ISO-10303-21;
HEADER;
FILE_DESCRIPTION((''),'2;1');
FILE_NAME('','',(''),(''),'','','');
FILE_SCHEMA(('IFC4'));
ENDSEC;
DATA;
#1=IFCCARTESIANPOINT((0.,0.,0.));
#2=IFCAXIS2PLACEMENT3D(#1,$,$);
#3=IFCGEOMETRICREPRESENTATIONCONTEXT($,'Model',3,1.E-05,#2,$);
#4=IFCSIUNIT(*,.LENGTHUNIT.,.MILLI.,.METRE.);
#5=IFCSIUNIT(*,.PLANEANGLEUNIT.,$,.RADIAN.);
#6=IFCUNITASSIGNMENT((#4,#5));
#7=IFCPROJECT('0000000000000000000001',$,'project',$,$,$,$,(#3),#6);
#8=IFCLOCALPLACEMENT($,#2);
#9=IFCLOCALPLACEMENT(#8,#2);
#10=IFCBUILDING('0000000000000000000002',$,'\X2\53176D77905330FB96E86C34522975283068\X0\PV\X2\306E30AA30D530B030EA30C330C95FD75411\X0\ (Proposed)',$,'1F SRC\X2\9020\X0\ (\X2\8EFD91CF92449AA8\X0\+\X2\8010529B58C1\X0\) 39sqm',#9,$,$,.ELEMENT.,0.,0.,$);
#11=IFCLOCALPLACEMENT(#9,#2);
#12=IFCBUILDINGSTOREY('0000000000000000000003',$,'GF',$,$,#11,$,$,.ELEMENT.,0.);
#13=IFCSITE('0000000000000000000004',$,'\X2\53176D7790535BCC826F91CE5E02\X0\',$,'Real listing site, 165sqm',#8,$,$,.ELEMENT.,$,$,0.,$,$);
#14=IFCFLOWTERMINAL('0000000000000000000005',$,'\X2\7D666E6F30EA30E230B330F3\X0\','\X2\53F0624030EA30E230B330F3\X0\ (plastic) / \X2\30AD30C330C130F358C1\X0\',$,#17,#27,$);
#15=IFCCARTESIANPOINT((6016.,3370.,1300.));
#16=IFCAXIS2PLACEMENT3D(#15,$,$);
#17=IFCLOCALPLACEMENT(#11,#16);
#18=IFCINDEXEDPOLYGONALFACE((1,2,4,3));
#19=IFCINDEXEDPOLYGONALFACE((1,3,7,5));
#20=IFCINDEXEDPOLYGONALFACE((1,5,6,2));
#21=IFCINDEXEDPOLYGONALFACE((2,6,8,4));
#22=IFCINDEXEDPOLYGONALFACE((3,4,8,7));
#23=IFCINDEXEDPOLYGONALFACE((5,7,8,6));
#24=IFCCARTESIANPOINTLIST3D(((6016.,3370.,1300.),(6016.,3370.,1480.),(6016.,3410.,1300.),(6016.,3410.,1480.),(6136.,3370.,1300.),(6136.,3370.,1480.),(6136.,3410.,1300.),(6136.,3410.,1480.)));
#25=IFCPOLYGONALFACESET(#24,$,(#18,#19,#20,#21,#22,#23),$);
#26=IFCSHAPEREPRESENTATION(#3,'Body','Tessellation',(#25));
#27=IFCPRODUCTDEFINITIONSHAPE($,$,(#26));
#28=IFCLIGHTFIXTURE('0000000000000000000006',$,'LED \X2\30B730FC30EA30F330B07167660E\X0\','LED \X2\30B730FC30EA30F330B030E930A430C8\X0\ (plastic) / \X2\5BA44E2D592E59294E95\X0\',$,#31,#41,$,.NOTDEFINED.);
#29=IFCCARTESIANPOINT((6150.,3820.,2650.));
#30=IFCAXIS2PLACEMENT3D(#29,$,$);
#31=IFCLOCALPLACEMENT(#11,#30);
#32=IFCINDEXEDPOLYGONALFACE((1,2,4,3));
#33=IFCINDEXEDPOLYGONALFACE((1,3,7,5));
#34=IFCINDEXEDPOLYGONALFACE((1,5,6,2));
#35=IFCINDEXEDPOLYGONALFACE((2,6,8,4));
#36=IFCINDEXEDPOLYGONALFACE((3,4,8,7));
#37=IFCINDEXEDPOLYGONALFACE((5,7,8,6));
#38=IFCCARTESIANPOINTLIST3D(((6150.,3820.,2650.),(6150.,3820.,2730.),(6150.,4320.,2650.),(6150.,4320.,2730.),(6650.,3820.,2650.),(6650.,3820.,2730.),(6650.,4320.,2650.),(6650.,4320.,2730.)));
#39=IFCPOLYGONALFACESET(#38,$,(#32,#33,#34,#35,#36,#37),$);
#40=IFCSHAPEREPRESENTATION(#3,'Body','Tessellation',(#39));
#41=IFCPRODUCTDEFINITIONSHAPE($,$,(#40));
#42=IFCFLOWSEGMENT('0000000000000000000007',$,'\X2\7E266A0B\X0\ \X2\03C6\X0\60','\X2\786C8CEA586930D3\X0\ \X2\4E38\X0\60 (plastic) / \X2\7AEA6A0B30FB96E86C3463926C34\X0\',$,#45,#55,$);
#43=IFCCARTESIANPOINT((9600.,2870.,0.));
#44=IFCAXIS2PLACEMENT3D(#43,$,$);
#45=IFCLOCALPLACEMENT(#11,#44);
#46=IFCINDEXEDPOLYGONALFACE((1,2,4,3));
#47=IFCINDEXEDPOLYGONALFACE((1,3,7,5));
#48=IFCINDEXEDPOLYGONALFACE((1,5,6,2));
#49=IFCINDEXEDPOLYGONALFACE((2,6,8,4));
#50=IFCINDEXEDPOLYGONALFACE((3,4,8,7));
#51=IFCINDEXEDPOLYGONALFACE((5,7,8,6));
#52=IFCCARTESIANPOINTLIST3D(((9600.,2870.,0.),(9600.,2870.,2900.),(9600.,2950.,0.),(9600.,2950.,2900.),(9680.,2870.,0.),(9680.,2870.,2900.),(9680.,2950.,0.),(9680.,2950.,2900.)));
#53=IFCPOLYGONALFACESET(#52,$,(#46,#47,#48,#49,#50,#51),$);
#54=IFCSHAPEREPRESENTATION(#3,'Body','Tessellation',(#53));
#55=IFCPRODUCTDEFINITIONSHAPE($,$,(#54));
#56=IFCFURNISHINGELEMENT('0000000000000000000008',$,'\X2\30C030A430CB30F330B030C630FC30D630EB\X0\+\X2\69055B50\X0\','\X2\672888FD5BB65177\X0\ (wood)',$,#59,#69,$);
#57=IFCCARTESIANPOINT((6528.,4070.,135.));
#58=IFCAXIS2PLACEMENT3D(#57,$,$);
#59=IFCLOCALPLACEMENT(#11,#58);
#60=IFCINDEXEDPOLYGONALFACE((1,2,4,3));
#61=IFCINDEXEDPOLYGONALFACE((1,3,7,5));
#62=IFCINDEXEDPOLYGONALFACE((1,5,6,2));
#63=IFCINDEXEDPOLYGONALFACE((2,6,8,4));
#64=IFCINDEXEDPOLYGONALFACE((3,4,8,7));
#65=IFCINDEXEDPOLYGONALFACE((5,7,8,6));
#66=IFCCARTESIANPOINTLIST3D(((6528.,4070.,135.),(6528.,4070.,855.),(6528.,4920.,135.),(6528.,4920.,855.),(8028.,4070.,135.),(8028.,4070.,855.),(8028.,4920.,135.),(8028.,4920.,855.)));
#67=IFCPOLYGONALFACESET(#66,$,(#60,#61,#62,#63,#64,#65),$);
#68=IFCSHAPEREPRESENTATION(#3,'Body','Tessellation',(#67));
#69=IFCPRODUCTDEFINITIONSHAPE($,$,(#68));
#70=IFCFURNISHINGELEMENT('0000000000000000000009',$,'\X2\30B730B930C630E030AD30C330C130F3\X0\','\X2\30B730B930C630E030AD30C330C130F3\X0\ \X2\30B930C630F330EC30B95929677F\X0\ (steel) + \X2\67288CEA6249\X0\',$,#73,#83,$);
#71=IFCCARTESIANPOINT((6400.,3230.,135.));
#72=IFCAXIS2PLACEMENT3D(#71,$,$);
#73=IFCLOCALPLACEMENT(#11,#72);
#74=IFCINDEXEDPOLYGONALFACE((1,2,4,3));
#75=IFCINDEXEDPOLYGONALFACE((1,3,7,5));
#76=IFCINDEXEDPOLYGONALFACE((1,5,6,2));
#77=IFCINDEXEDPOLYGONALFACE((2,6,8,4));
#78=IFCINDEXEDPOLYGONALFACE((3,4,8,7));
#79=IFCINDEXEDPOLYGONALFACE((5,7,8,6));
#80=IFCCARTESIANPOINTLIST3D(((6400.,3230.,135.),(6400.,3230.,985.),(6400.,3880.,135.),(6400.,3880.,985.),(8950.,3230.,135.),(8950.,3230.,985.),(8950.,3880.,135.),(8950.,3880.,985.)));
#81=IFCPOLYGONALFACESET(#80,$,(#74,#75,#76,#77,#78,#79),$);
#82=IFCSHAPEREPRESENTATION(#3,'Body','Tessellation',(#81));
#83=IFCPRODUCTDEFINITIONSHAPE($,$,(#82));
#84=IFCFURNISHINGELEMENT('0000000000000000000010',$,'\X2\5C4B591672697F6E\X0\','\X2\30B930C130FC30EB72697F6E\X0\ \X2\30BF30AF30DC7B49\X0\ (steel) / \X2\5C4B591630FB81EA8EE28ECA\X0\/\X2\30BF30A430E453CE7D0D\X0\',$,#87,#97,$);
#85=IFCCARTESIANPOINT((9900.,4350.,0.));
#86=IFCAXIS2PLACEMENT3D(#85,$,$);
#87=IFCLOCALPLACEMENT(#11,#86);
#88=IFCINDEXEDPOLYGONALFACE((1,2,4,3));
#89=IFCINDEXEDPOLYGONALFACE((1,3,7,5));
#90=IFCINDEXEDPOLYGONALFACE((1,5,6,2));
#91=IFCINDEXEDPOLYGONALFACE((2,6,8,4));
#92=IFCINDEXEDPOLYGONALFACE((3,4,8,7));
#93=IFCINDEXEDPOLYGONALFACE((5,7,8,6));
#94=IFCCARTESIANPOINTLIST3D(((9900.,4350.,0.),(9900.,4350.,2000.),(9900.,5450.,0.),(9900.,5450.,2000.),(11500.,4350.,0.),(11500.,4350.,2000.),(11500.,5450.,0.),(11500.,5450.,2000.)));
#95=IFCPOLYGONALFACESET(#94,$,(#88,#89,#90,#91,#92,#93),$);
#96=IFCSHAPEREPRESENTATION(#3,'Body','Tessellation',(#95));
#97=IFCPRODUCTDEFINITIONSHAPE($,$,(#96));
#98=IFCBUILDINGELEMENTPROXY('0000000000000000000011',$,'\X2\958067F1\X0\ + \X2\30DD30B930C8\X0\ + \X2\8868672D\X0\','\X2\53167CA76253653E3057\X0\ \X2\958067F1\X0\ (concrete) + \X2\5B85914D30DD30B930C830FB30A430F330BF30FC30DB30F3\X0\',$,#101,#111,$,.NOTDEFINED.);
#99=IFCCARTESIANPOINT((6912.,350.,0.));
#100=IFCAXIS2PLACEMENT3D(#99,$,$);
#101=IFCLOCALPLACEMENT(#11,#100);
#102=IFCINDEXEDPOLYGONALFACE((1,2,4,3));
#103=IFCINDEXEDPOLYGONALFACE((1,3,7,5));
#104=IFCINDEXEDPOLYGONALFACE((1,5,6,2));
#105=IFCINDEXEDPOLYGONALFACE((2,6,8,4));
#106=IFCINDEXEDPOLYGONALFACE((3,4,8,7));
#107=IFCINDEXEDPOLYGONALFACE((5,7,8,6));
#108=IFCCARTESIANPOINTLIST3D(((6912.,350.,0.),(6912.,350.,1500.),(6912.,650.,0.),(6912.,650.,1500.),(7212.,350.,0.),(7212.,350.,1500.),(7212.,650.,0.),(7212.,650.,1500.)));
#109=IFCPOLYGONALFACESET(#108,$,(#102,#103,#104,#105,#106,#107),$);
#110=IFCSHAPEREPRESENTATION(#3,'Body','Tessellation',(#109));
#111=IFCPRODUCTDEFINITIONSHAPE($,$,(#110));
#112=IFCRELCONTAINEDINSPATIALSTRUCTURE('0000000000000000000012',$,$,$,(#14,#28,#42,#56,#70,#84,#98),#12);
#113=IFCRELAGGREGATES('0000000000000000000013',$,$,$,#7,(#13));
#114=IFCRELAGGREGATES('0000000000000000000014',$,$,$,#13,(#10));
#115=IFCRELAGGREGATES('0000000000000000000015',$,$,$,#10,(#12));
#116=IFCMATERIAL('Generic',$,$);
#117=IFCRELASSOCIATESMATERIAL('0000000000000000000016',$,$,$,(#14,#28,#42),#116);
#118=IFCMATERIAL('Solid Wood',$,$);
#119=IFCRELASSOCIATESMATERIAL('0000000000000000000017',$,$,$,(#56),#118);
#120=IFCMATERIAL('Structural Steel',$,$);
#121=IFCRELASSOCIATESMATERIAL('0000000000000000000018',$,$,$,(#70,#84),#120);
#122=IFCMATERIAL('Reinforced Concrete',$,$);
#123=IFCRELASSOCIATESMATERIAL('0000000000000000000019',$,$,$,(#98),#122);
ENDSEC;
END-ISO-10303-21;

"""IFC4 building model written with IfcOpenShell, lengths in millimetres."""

from ifc_helpers import new_model, si_unit, frame, frame_2d, origin, place, context, project, spatial, rectangle, extrude, material, element, save


model = new_model("IFC4")

# Units and contexts
model_context = context("Model", 3, precision=1e-05, world=origin())
ifc_project = project(units=[si_unit("LENGTHUNIT", "METRE", prefix="MILLI"), si_unit("PLANEANGLEUNIT", "RADIAN")], contexts=[model_context])

# Site, building, storey
site_placement = place(None, origin())
site = spatial("IfcSite", under=ifc_project, at=site_placement, Name="北海道富良野市", ObjectType="Real listing site, 165sqm", CompositionType="ELEMENT", RefElevation=0.0)
building_placement = place(site_placement, origin())
building = spatial("IfcBuilding", under=site, at=building_placement, Name="北海道・雨水利用とPVのオフグリッド志向 (Proposed)", ObjectType="1F SRC造 (軽量鉄骨+耐力壁) 39sqm", CompositionType="ELEMENT", ElevationOfRefHeight=0.0, ElevationOfTerrain=0.0)
storey_placement = place(building_placement, origin())
storey = spatial("IfcBuildingStorey", under=building, at=storey_placement, Name="GF", CompositionType="ELEMENT", Elevation=0.0)

# Shared definitions
ifc_material_1 = material(Name="Solid Wood")

# Shared definitions
ifc_material_2 = material(Name="Structural Steel")

# Shared definitions
ifc_material_3 = material(Name="Reinforced Concrete")

# Flow terminal
ifc_material_4 = material(Name="Generic")
flow_terminal_1_placement = place(storey_placement, frame((6016.0, 3370.0, 1300.0)))
element("IfcFlowTerminal", 1, at=flow_terminal_1_placement, inside=storey, material=ifc_material_4, Name="給湯リモコン", Description="台所リモコン (plastic) / キッチン壁", context=model_context, shape_type="SweptSolid", body=[
    extrude(rectangle(XDim=120.0, YDim=40.0, at=frame_2d((60.0, 20.0))), frame((6016.0, 3370.0, 1300.0)), (0.0, 0.0, 1.0), 180.0),
])

# Light fixture
light_fixture_placement = place(storey_placement, frame((6150.0, 3820.0, 2650.0)))
element("IfcLightFixture", 2, at=light_fixture_placement, inside=storey, material=ifc_material_4, Name="LED シーリング照明", Description="LED シーリングライト (plastic) / 室中央天井", PredefinedType="NOTDEFINED", context=model_context, shape_type="SweptSolid", body=[
    extrude(rectangle(XDim=500.0, YDim=500.0, at=frame_2d((250.0, 250.0))), frame((6150.0, 3820.0, 2650.0)), (0.0, 0.0, 1.0), 80.0),
])

# Flow segment
flow_segment_placement = place(storey_placement, frame((9600.0, 2870.0, 0.0)))
element("IfcFlowSegment", 3, at=flow_segment_placement, inside=storey, material=ifc_material_4, Name="縦樋 φ60", Description="硬質塩ビ 丸60 (plastic) / 竪樋・雨水排水", context=model_context, shape_type="SweptSolid", body=[
    extrude(rectangle(XDim=80.0, YDim=80.0, at=frame_2d((40.0, 40.0))), frame((9600.0, 2870.0, 0.0)), (0.0, 0.0, 1.0), 2900.0),
])

# Furnishing elements
furnishing_1_placement = place(storey_placement, frame((6528.0, 4070.0, 135.0)))
element("IfcFurnishingElement", 4, at=furnishing_1_placement, inside=storey, material=ifc_material_1, Name="ダイニングテーブル+椅子", Description="木製家具 (wood)", context=model_context, shape_type="SweptSolid", body=[
    extrude(rectangle(XDim=1500.0, YDim=850.0, at=frame_2d((750.0, 425.0))), frame((6528.0, 4070.0, 135.0)), (0.0, 0.0, 1.0), 720.0),
])
furnishing_2_placement = place(storey_placement, frame((6400.0, 3230.0, 135.0)))
element("IfcFurnishingElement", 5, at=furnishing_2_placement, inside=storey, material=ifc_material_2, Name="システムキッチン", Description="システムキッチン ステンレス天板 (steel) + 木質扉", context=model_context, shape_type="SweptSolid", body=[
    extrude(rectangle(XDim=2550.0, YDim=650.0, at=frame_2d((1275.0, 325.0))), frame((6400.0, 3230.0, 135.0)), (0.0, 0.0, 1.0), 850.0),
])
furnishing_3_placement = place(storey_placement, frame((9900.0, 4350.0, 0.0)))
element("IfcFurnishingElement", 6, at=furnishing_3_placement, inside=storey, material=ifc_material_2, Name="屋外物置", Description="スチール物置 タクボ等 (steel) / 屋外・自転車/タイヤ収納", context=model_context, shape_type="SweptSolid", body=[
    extrude(rectangle(XDim=1600.0, YDim=1100.0, at=frame_2d((800.0, 550.0))), frame((9900.0, 4350.0, 0.0)), (0.0, 0.0, 1.0), 2000.0),
])

# Building element proxy
proxy_placement = place(storey_placement, frame((6912.0, 350.0, 0.0)))
element("IfcBuildingElementProxy", 7, at=proxy_placement, inside=storey, material=ifc_material_3, Name="門柱 + ポスト + 表札", Description="化粧打放し 門柱 (concrete) + 宅配ポスト・インターホン", PredefinedType="NOTDEFINED", context=model_context, shape_type="SweptSolid", body=[
    extrude(rectangle(XDim=300.0, YDim=300.0, at=frame_2d((150.0, 150.0))), frame((6912.0, 350.0, 0.0)), (0.0, 0.0, 1.0), 1500.0),
])

save(model, "model.ifc")
